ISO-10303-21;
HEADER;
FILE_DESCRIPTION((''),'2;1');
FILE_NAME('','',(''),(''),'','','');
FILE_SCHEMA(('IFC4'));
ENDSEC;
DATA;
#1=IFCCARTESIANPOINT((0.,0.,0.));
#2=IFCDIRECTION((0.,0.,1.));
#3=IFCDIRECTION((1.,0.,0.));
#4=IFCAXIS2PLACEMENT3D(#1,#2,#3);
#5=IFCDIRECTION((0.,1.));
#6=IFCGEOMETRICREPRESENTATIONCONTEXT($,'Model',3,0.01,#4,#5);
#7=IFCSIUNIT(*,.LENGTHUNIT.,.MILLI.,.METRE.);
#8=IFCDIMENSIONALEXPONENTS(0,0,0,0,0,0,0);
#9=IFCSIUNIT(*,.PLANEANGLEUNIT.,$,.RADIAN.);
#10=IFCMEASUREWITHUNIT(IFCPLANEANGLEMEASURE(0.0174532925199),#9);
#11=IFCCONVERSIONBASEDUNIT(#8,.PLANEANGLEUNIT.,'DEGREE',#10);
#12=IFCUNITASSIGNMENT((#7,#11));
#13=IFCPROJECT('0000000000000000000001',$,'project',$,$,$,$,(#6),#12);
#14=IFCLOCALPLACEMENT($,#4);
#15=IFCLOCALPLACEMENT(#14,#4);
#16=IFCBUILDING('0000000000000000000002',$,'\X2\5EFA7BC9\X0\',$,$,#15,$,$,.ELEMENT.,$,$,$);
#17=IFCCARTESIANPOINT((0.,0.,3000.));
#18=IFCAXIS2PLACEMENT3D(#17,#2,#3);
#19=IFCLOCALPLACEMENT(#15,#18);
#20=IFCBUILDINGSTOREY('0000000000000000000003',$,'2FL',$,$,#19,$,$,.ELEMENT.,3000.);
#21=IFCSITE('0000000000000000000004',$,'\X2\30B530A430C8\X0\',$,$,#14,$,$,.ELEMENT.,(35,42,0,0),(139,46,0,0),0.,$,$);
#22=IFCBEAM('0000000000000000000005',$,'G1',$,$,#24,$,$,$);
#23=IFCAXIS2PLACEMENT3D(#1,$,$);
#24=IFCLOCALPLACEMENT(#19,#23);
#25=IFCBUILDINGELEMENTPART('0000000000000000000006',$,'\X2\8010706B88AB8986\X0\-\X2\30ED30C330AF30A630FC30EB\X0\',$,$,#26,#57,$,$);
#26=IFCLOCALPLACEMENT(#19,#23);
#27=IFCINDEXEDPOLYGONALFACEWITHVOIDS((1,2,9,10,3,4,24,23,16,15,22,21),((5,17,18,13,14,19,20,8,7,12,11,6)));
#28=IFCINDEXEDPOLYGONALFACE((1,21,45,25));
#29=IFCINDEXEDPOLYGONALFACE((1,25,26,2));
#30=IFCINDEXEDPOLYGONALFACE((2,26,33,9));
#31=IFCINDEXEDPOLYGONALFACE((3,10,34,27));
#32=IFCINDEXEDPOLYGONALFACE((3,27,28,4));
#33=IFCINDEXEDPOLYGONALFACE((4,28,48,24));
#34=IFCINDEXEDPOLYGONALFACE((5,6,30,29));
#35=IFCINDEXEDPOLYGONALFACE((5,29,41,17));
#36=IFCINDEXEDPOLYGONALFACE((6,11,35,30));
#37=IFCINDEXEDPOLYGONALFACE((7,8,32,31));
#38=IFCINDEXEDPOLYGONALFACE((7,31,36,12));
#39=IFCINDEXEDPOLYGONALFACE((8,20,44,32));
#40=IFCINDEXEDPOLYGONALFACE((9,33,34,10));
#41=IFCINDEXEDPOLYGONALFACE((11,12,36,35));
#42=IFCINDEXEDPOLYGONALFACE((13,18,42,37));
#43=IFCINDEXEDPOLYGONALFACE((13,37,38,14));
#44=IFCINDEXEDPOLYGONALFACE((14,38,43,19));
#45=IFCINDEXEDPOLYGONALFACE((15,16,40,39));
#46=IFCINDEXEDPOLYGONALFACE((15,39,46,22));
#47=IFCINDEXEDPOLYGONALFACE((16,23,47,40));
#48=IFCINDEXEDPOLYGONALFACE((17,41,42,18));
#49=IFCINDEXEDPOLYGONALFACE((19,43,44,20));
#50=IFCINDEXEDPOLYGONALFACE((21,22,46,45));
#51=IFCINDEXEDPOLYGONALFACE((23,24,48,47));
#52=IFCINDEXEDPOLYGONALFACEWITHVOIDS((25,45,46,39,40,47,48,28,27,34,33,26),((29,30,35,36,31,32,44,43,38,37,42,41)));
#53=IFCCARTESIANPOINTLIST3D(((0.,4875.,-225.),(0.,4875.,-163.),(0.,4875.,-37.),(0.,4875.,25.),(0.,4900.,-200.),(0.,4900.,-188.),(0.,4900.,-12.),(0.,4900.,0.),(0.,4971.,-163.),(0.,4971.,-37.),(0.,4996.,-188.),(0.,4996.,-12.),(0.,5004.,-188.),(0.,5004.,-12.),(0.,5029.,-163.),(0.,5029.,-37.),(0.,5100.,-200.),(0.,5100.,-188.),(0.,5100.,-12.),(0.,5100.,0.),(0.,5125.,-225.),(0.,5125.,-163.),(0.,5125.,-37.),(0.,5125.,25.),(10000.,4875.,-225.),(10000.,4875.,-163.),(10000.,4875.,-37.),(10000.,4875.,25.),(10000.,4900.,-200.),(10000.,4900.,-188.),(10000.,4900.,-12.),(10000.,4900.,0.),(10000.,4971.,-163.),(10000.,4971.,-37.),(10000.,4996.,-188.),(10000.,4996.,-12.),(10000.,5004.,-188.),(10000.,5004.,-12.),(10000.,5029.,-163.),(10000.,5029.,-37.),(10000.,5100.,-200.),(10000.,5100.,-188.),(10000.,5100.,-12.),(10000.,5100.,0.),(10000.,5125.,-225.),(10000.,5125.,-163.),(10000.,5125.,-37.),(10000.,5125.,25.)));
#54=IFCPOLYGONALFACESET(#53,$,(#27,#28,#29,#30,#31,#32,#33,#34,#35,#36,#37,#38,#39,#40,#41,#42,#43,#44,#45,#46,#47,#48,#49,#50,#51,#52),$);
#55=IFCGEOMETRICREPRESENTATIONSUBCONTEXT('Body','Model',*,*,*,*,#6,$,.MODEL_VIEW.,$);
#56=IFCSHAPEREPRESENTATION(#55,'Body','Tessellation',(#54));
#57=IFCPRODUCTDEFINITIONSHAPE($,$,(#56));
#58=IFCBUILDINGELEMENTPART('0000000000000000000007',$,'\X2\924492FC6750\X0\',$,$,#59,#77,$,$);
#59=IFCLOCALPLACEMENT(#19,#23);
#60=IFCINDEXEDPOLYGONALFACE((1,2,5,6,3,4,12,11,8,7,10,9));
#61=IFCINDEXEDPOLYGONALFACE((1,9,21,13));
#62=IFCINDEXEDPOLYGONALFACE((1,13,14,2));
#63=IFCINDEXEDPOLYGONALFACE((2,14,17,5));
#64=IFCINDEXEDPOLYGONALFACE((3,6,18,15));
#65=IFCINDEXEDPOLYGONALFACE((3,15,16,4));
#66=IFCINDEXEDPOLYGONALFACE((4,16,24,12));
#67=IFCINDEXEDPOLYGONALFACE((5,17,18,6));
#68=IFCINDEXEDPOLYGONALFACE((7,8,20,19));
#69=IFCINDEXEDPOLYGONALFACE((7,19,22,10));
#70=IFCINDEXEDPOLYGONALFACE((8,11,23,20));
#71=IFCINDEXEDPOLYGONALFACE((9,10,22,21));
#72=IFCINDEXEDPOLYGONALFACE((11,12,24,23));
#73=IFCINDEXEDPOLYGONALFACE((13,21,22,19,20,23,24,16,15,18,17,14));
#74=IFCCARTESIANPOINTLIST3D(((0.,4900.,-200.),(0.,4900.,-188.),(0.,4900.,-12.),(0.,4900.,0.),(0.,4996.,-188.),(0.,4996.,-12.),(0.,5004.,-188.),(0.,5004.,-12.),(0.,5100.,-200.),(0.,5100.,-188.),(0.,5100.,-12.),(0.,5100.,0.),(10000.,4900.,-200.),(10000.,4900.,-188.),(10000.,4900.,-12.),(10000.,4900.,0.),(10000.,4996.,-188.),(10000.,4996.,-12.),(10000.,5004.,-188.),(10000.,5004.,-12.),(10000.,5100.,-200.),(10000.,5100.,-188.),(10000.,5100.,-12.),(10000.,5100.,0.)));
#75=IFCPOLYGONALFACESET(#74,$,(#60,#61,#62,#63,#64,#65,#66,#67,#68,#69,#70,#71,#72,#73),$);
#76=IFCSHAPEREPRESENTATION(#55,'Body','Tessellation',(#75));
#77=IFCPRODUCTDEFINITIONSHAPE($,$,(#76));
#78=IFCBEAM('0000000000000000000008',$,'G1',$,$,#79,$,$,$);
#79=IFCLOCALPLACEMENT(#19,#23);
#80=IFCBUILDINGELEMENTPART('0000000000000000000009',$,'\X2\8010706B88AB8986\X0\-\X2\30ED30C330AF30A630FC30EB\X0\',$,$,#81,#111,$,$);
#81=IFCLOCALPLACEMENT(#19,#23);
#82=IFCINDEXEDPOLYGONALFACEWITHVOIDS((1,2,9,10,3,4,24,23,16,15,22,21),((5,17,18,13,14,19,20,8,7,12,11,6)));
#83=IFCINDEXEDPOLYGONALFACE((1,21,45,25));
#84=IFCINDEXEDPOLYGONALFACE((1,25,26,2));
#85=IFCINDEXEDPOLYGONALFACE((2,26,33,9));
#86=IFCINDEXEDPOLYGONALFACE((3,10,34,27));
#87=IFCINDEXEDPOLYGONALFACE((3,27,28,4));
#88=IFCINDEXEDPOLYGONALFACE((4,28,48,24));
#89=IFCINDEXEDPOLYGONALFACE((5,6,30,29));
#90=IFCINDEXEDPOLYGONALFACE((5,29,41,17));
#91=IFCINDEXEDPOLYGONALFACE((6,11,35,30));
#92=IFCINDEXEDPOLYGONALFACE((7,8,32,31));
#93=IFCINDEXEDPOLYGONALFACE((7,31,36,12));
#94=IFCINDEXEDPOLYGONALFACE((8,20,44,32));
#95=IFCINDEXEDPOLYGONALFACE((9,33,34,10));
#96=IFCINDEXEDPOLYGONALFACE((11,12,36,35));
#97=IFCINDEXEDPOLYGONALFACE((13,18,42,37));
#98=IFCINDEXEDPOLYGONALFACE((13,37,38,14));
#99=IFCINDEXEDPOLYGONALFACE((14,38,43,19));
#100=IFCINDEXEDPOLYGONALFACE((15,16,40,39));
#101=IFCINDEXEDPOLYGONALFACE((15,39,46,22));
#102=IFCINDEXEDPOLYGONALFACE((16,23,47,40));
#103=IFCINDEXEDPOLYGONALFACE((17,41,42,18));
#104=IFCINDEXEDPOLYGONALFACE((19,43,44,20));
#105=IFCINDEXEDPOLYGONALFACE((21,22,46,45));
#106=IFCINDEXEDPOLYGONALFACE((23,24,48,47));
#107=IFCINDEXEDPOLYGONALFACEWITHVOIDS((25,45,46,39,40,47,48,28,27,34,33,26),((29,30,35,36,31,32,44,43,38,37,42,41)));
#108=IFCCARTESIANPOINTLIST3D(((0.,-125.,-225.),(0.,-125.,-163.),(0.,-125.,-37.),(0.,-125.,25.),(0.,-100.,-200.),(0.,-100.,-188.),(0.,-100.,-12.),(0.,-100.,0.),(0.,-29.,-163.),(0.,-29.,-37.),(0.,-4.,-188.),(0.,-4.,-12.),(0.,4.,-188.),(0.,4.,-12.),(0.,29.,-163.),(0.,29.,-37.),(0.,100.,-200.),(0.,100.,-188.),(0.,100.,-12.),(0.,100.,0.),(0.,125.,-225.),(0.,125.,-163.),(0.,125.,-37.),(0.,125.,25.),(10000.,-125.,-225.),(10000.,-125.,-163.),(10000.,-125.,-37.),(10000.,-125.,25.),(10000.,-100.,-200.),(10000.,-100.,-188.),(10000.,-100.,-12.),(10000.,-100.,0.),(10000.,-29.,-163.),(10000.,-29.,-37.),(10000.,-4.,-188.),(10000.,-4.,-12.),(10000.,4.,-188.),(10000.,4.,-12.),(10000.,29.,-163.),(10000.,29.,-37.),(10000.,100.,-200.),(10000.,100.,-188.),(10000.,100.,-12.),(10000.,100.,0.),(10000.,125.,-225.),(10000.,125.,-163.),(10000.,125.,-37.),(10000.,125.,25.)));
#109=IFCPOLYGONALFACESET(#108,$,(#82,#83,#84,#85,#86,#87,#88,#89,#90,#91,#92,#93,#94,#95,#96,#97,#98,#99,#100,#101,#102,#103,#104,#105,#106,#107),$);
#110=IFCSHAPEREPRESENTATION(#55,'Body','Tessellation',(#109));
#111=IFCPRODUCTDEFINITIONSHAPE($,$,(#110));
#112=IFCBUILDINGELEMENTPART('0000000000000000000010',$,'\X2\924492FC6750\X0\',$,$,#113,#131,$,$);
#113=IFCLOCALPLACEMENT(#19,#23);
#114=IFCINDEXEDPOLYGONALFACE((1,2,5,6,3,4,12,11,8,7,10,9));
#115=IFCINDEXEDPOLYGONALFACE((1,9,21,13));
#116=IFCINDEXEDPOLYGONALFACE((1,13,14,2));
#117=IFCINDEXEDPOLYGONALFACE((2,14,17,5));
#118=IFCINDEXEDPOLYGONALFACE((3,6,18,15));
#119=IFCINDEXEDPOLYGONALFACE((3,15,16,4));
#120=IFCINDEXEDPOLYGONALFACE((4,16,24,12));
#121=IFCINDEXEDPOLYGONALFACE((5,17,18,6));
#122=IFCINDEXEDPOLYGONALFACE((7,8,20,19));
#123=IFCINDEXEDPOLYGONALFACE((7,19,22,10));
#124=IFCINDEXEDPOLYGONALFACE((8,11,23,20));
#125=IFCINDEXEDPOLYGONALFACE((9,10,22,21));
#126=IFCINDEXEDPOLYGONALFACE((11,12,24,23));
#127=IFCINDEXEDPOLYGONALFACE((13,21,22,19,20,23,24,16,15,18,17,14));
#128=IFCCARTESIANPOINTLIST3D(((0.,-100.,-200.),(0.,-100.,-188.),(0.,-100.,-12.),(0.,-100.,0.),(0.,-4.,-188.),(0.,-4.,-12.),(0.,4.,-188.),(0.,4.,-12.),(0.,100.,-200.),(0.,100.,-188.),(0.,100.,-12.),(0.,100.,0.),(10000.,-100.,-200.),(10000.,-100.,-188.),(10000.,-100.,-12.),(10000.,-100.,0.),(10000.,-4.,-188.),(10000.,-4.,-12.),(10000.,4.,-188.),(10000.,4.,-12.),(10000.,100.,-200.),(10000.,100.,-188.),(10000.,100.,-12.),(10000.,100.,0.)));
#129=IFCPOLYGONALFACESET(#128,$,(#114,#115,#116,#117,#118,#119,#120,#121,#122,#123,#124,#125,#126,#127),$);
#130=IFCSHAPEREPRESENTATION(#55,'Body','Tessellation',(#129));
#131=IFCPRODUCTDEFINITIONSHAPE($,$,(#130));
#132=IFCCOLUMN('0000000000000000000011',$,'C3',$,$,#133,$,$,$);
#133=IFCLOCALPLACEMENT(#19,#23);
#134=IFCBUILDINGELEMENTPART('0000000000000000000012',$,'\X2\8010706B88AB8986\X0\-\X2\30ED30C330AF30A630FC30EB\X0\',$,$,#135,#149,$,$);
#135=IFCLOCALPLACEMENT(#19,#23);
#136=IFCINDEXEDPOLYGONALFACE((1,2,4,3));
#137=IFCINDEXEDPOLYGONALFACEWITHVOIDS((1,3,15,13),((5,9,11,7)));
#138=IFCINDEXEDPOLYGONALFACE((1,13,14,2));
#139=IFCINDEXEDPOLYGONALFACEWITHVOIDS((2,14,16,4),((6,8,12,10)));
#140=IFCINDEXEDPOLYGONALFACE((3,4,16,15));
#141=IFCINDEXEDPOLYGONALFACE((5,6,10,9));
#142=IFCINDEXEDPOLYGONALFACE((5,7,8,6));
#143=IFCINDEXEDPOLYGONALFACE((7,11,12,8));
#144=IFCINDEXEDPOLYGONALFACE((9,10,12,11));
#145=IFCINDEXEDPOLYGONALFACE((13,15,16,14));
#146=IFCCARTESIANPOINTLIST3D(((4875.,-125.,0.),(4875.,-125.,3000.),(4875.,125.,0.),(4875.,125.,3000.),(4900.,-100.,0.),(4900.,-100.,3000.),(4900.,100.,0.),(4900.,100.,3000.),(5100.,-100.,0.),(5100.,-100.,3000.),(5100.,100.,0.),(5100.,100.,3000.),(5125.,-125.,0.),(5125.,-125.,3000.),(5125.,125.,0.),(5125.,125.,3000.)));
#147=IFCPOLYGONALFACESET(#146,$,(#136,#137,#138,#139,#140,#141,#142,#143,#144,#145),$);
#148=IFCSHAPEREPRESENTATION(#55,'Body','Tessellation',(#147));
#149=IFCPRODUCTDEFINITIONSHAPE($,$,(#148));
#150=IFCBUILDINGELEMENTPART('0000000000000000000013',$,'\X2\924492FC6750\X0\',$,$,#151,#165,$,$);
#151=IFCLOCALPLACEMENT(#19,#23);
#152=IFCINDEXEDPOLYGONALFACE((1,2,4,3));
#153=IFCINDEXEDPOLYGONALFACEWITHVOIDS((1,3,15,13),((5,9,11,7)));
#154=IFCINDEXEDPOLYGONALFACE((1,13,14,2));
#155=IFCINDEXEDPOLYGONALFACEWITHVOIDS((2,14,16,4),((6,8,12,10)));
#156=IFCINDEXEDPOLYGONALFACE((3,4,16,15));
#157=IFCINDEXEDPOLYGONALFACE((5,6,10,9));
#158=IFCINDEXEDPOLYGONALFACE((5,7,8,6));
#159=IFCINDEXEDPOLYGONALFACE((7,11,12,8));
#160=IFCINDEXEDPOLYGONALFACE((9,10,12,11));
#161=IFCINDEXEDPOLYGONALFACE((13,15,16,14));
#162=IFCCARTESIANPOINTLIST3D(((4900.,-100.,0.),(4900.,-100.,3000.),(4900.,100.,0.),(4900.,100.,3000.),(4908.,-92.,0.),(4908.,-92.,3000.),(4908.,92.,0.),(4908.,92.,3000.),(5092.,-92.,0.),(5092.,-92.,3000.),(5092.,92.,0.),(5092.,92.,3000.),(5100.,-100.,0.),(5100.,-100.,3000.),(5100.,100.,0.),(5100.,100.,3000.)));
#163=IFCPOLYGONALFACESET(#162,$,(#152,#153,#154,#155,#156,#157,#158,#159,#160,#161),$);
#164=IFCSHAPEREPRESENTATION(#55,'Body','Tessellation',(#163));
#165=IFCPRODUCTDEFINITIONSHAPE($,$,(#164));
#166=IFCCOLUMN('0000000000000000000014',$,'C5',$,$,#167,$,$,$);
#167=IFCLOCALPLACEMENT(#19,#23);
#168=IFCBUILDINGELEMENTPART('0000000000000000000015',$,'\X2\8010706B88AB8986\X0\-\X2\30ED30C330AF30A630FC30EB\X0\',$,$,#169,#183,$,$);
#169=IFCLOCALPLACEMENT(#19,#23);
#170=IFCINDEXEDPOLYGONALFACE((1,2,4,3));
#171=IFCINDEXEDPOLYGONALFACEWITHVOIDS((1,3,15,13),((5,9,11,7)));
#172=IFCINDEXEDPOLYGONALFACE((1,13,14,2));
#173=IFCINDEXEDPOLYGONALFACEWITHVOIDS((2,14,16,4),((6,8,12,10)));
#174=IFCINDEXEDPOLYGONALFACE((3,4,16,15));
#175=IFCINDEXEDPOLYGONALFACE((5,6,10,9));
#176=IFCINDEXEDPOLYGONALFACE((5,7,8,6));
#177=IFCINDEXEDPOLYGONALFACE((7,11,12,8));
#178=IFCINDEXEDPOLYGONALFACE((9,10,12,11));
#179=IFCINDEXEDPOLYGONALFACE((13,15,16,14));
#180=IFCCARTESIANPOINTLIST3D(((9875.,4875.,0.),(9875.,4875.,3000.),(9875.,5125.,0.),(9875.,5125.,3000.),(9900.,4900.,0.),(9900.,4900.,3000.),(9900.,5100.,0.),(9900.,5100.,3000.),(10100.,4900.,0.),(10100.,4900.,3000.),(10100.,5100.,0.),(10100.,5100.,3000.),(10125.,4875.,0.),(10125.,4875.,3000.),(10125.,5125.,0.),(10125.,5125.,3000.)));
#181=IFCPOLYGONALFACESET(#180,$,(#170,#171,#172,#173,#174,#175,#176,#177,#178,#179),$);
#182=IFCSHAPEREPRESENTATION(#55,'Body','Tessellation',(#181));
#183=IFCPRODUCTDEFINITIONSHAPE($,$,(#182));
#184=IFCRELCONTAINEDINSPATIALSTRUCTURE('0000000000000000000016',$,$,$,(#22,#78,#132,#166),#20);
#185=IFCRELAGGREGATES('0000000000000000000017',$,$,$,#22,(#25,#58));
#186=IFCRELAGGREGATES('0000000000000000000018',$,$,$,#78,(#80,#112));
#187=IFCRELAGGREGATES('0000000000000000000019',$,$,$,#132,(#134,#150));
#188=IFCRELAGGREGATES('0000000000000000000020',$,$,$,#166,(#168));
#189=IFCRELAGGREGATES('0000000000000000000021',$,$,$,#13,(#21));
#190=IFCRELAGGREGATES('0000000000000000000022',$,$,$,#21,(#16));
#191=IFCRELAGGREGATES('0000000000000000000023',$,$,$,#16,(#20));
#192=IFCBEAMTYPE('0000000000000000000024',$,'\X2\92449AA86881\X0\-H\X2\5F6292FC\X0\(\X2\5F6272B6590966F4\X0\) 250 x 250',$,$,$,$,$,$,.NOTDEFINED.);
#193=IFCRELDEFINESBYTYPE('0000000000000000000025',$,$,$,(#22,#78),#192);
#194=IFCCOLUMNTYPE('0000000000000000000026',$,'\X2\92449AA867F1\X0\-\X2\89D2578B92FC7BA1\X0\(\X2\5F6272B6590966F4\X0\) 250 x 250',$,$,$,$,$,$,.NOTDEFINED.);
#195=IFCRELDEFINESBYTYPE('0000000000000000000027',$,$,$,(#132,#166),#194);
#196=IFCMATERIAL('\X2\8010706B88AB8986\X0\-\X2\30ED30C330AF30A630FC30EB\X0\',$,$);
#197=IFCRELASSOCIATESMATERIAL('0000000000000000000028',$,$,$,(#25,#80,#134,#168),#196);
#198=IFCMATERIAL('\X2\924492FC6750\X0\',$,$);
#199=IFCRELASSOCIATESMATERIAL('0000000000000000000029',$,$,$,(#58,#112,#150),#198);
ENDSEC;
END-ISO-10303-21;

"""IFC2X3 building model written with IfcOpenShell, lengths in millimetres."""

from ifc_helpers import new_model, entity, si_unit, converted_unit, direction, frame, origin_with_axes, place, context, subcontext, project, spatial, polyline, outline, extrude, material, type_object, element, aggregate, save


model = new_model("IFC2X3")

# Units and contexts
model_context = context("Model", 3, precision=0.01, world=origin_with_axes(), true_north=direction((0.0, 1.0)))
body_context = subcontext(model_context, "Body", "Model", "MODEL_VIEW")
ifc_project = project(units=[si_unit("LENGTHUNIT", "METRE", prefix="MILLI"), converted_unit("PLANEANGLEUNIT", "DEGREE", entity("IfcPlaneAngleMeasure", 0.0174532925199), si_unit("PLANEANGLEUNIT", "RADIAN"), dimensions=[0, 0, 0, 0, 0, 0, 0])], contexts=[model_context])

# Site, building, storey
site_placement = place(None, origin_with_axes())
site = spatial("IfcSite", under=ifc_project, at=site_placement, Name="サイト", CompositionType="ELEMENT", RefLatitude=(35, 42, 0, 0), RefLongitude=(139, 46, 0, 0), RefElevation=0.0)
building_placement = place(site_placement, origin_with_axes())
building = spatial("IfcBuilding", under=site, at=building_placement, Name="建築", CompositionType="ELEMENT")
storey_placement = place(building_placement, frame((0.0, 0.0, 3000.0), z_axis=(0.0, 0.0, 1.0), x_axis=(1.0, 0.0, 0.0)))
storey = spatial("IfcBuildingStorey", under=building, at=storey_placement, Name="2FL", CompositionType="ELEMENT", Elevation=3000.0)

# Beams, building element parts
beam_type_1 = type_object("IfcBeamType", Name="鉄骨梁-H形鋼(形状変更) 250 x 250", PredefinedType="NOTDEFINED")
beam_1_placement = place(storey_placement, frame((0.0, 5000.0, 0.0), z_axis=(0.0, 0.0, 1.0), x_axis=(0.0, -1.0, 0.0)))
beam_1 = element("IfcBeam", 1, at=beam_1_placement, inside=storey, type_object=beam_type_1, Name="G1")
ifc_material_1 = material(Name="耐火被覆-ロックウール")
building_element_part_1_placement = place(beam_1_placement, origin_with_axes())
building_element_part_1 = element("IfcBuildingElementPart", 2, at=building_element_part_1_placement, material=ifc_material_1, Name="耐火被覆-ロックウール", context=body_context, shape_type="SweptSolid", body=[
    extrude(outline(polyline([(-125.0, 25.0), (-125.0, -37.0), (-29.0, -37.0), (-29.0, -163.0), (-125.0, -163.0), (-125.0, -225.0), (125.0, -225.0), (125.0, -163.0), (29.0, -163.0), (29.0, -37.0), (125.0, -37.0), (125.0, 25.0), (-125.0, 25.0)]), holes=[polyline([(-100.0, -188.0), (-4.0, -188.0), (-4.0, -12.0), (-100.0, -12.0), (-100.0, 0.0), (100.0, 0.0), (100.0, -12.0), (4.0, -12.0), (4.0, -188.0), (100.0, -188.0), (100.0, -200.0), (-100.0, -200.0), (-100.0, -188.0)])]), frame((0.0, 10000.0, 0.0), z_axis=(0.0, -1.0, 0.0), x_axis=(1.0, 0.0, 0.0)), (0.0, 0.0, 1.0), 10000.0),
])
ifc_material_2 = material(Name="鉄鋼材")
building_element_part_2_placement = place(beam_1_placement, origin_with_axes())
building_element_part_2 = element("IfcBuildingElementPart", 3, at=building_element_part_2_placement, material=ifc_material_2, Name="鉄鋼材", context=body_context, shape_type="SweptSolid", body=[
    extrude(outline(polyline([(-100.0, 0.0), (-100.0, -12.0), (-4.0, -12.0), (-4.0, -188.0), (-100.0, -188.0), (-100.0, -200.0), (100.0, -200.0), (100.0, -188.0), (4.0, -188.0), (4.0, -12.0), (100.0, -12.0), (100.0, 0.0), (-100.0, 0.0)])), frame((0.0, 10000.0, 0.0), z_axis=(0.0, -1.0, 0.0), x_axis=(1.0, 0.0, 0.0)), (0.0, 0.0, 1.0), 10000.0),
])
aggregate(beam_1, [building_element_part_1, building_element_part_2])
beam_2_placement = place(storey_placement, frame((0.0, 0.0, 0.0), z_axis=(0.0, 0.0, 1.0), x_axis=(0.0, -1.0, 0.0)))
beam_2 = element("IfcBeam", 4, at=beam_2_placement, inside=storey, type_object=beam_type_1, Name="G1")
building_element_part_3_placement = place(beam_2_placement, origin_with_axes())
building_element_part_3 = element("IfcBuildingElementPart", 5, at=building_element_part_3_placement, material=ifc_material_1, Name="耐火被覆-ロックウール", context=body_context, shape_type="SweptSolid", body=[
    extrude(outline(polyline([(-125.0, 25.0), (-125.0, -37.0), (-29.0, -37.0), (-29.0, -163.0), (-125.0, -163.0), (-125.0, -225.0), (125.0, -225.0), (125.0, -163.0), (29.0, -163.0), (29.0, -37.0), (125.0, -37.0), (125.0, 25.0), (-125.0, 25.0)]), holes=[polyline([(-100.0, -188.0), (-4.0, -188.0), (-4.0, -12.0), (-100.0, -12.0), (-100.0, 0.0), (100.0, 0.0), (100.0, -12.0), (4.0, -12.0), (4.0, -188.0), (100.0, -188.0), (100.0, -200.0), (-100.0, -200.0), (-100.0, -188.0)])]), frame((0.0, 10000.0, 0.0), z_axis=(0.0, -1.0, 0.0), x_axis=(1.0, 0.0, 0.0)), (0.0, 0.0, 1.0), 10000.0),
])
building_element_part_4_placement = place(beam_2_placement, origin_with_axes())
building_element_part_4 = element("IfcBuildingElementPart", 6, at=building_element_part_4_placement, material=ifc_material_2, Name="鉄鋼材", context=body_context, shape_type="SweptSolid", body=[
    extrude(outline(polyline([(-100.0, 0.0), (-100.0, -12.0), (-4.0, -12.0), (-4.0, -188.0), (-100.0, -188.0), (-100.0, -200.0), (100.0, -200.0), (100.0, -188.0), (4.0, -188.0), (4.0, -12.0), (100.0, -12.0), (100.0, 0.0), (-100.0, 0.0)])), frame((0.0, 10000.0, 0.0), z_axis=(0.0, -1.0, 0.0), x_axis=(1.0, 0.0, 0.0)), (0.0, 0.0, 1.0), 10000.0),
])
aggregate(beam_2, [building_element_part_3, building_element_part_4])

# Columns, building element parts
column_type_1 = type_object("IfcColumnType", Name="鉄骨柱-角型鋼管(形状変更) 250 x 250", PredefinedType="NOTDEFINED")
column_1_placement = place(storey_placement, frame((5000.0, 0.0, 0.0), z_axis=(0.0, 0.0, 1.0), x_axis=(1.0, 0.0, 0.0)))
column_1 = element("IfcColumn", 7, at=column_1_placement, inside=storey, type_object=column_type_1, Name="C3")
building_element_part_5_placement = place(column_1_placement, origin_with_axes())
building_element_part_5 = element("IfcBuildingElementPart", 8, at=building_element_part_5_placement, material=ifc_material_1, Name="耐火被覆-ロックウール", context=body_context, shape_type="SweptSolid", body=[
    extrude(outline(polyline([(-125.0, -125.0), (125.0, -125.0), (125.0, 125.0), (-125.0, 125.0), (-125.0, -125.0)]), holes=[polyline([(-100.0, 100.0), (100.0, 100.0), (100.0, -100.0), (-100.0, -100.0), (-100.0, 100.0)])]), origin_with_axes(), (0.0, 0.0, 1.0), 3000.0),
])
building_element_part_6_placement = place(column_1_placement, origin_with_axes())
building_element_part_6 = element("IfcBuildingElementPart", 9, at=building_element_part_6_placement, material=ifc_material_2, Name="鉄鋼材", context=body_context, shape_type="SweptSolid", body=[
    extrude(outline(polyline([(-100.0, -100.0), (100.0, -100.0), (100.0, 100.0), (-100.0, 100.0), (-100.0, -100.0)]), holes=[polyline([(92.0, -92.0), (-92.0, -92.0), (-92.0, 92.0), (92.0, 92.0), (92.0, -92.0)])]), origin_with_axes(), (0.0, 0.0, 1.0), 3000.0),
])
aggregate(column_1, [building_element_part_5, building_element_part_6])
column_2_placement = place(storey_placement, frame((10000.0, 5000.0, 0.0), z_axis=(0.0, 0.0, 1.0), x_axis=(1.0, 0.0, 0.0)))
column_2 = element("IfcColumn", 10, at=column_2_placement, inside=storey, type_object=column_type_1, Name="C5")
building_element_part_7_placement = place(column_2_placement, origin_with_axes())
building_element_part_7 = element("IfcBuildingElementPart", 11, at=building_element_part_7_placement, material=ifc_material_1, Name="耐火被覆-ロックウール", context=body_context, shape_type="SweptSolid", body=[
    extrude(outline(polyline([(-125.0, -125.0), (125.0, -125.0), (125.0, 125.0), (-125.0, 125.0), (-125.0, -125.0)]), holes=[polyline([(-100.0, 100.0), (100.0, 100.0), (100.0, -100.0), (-100.0, -100.0), (-100.0, 100.0)])]), origin_with_axes(), (0.0, 0.0, 1.0), 3000.0),
])
aggregate(column_2, [building_element_part_7])

save(model, "model.ifc")
